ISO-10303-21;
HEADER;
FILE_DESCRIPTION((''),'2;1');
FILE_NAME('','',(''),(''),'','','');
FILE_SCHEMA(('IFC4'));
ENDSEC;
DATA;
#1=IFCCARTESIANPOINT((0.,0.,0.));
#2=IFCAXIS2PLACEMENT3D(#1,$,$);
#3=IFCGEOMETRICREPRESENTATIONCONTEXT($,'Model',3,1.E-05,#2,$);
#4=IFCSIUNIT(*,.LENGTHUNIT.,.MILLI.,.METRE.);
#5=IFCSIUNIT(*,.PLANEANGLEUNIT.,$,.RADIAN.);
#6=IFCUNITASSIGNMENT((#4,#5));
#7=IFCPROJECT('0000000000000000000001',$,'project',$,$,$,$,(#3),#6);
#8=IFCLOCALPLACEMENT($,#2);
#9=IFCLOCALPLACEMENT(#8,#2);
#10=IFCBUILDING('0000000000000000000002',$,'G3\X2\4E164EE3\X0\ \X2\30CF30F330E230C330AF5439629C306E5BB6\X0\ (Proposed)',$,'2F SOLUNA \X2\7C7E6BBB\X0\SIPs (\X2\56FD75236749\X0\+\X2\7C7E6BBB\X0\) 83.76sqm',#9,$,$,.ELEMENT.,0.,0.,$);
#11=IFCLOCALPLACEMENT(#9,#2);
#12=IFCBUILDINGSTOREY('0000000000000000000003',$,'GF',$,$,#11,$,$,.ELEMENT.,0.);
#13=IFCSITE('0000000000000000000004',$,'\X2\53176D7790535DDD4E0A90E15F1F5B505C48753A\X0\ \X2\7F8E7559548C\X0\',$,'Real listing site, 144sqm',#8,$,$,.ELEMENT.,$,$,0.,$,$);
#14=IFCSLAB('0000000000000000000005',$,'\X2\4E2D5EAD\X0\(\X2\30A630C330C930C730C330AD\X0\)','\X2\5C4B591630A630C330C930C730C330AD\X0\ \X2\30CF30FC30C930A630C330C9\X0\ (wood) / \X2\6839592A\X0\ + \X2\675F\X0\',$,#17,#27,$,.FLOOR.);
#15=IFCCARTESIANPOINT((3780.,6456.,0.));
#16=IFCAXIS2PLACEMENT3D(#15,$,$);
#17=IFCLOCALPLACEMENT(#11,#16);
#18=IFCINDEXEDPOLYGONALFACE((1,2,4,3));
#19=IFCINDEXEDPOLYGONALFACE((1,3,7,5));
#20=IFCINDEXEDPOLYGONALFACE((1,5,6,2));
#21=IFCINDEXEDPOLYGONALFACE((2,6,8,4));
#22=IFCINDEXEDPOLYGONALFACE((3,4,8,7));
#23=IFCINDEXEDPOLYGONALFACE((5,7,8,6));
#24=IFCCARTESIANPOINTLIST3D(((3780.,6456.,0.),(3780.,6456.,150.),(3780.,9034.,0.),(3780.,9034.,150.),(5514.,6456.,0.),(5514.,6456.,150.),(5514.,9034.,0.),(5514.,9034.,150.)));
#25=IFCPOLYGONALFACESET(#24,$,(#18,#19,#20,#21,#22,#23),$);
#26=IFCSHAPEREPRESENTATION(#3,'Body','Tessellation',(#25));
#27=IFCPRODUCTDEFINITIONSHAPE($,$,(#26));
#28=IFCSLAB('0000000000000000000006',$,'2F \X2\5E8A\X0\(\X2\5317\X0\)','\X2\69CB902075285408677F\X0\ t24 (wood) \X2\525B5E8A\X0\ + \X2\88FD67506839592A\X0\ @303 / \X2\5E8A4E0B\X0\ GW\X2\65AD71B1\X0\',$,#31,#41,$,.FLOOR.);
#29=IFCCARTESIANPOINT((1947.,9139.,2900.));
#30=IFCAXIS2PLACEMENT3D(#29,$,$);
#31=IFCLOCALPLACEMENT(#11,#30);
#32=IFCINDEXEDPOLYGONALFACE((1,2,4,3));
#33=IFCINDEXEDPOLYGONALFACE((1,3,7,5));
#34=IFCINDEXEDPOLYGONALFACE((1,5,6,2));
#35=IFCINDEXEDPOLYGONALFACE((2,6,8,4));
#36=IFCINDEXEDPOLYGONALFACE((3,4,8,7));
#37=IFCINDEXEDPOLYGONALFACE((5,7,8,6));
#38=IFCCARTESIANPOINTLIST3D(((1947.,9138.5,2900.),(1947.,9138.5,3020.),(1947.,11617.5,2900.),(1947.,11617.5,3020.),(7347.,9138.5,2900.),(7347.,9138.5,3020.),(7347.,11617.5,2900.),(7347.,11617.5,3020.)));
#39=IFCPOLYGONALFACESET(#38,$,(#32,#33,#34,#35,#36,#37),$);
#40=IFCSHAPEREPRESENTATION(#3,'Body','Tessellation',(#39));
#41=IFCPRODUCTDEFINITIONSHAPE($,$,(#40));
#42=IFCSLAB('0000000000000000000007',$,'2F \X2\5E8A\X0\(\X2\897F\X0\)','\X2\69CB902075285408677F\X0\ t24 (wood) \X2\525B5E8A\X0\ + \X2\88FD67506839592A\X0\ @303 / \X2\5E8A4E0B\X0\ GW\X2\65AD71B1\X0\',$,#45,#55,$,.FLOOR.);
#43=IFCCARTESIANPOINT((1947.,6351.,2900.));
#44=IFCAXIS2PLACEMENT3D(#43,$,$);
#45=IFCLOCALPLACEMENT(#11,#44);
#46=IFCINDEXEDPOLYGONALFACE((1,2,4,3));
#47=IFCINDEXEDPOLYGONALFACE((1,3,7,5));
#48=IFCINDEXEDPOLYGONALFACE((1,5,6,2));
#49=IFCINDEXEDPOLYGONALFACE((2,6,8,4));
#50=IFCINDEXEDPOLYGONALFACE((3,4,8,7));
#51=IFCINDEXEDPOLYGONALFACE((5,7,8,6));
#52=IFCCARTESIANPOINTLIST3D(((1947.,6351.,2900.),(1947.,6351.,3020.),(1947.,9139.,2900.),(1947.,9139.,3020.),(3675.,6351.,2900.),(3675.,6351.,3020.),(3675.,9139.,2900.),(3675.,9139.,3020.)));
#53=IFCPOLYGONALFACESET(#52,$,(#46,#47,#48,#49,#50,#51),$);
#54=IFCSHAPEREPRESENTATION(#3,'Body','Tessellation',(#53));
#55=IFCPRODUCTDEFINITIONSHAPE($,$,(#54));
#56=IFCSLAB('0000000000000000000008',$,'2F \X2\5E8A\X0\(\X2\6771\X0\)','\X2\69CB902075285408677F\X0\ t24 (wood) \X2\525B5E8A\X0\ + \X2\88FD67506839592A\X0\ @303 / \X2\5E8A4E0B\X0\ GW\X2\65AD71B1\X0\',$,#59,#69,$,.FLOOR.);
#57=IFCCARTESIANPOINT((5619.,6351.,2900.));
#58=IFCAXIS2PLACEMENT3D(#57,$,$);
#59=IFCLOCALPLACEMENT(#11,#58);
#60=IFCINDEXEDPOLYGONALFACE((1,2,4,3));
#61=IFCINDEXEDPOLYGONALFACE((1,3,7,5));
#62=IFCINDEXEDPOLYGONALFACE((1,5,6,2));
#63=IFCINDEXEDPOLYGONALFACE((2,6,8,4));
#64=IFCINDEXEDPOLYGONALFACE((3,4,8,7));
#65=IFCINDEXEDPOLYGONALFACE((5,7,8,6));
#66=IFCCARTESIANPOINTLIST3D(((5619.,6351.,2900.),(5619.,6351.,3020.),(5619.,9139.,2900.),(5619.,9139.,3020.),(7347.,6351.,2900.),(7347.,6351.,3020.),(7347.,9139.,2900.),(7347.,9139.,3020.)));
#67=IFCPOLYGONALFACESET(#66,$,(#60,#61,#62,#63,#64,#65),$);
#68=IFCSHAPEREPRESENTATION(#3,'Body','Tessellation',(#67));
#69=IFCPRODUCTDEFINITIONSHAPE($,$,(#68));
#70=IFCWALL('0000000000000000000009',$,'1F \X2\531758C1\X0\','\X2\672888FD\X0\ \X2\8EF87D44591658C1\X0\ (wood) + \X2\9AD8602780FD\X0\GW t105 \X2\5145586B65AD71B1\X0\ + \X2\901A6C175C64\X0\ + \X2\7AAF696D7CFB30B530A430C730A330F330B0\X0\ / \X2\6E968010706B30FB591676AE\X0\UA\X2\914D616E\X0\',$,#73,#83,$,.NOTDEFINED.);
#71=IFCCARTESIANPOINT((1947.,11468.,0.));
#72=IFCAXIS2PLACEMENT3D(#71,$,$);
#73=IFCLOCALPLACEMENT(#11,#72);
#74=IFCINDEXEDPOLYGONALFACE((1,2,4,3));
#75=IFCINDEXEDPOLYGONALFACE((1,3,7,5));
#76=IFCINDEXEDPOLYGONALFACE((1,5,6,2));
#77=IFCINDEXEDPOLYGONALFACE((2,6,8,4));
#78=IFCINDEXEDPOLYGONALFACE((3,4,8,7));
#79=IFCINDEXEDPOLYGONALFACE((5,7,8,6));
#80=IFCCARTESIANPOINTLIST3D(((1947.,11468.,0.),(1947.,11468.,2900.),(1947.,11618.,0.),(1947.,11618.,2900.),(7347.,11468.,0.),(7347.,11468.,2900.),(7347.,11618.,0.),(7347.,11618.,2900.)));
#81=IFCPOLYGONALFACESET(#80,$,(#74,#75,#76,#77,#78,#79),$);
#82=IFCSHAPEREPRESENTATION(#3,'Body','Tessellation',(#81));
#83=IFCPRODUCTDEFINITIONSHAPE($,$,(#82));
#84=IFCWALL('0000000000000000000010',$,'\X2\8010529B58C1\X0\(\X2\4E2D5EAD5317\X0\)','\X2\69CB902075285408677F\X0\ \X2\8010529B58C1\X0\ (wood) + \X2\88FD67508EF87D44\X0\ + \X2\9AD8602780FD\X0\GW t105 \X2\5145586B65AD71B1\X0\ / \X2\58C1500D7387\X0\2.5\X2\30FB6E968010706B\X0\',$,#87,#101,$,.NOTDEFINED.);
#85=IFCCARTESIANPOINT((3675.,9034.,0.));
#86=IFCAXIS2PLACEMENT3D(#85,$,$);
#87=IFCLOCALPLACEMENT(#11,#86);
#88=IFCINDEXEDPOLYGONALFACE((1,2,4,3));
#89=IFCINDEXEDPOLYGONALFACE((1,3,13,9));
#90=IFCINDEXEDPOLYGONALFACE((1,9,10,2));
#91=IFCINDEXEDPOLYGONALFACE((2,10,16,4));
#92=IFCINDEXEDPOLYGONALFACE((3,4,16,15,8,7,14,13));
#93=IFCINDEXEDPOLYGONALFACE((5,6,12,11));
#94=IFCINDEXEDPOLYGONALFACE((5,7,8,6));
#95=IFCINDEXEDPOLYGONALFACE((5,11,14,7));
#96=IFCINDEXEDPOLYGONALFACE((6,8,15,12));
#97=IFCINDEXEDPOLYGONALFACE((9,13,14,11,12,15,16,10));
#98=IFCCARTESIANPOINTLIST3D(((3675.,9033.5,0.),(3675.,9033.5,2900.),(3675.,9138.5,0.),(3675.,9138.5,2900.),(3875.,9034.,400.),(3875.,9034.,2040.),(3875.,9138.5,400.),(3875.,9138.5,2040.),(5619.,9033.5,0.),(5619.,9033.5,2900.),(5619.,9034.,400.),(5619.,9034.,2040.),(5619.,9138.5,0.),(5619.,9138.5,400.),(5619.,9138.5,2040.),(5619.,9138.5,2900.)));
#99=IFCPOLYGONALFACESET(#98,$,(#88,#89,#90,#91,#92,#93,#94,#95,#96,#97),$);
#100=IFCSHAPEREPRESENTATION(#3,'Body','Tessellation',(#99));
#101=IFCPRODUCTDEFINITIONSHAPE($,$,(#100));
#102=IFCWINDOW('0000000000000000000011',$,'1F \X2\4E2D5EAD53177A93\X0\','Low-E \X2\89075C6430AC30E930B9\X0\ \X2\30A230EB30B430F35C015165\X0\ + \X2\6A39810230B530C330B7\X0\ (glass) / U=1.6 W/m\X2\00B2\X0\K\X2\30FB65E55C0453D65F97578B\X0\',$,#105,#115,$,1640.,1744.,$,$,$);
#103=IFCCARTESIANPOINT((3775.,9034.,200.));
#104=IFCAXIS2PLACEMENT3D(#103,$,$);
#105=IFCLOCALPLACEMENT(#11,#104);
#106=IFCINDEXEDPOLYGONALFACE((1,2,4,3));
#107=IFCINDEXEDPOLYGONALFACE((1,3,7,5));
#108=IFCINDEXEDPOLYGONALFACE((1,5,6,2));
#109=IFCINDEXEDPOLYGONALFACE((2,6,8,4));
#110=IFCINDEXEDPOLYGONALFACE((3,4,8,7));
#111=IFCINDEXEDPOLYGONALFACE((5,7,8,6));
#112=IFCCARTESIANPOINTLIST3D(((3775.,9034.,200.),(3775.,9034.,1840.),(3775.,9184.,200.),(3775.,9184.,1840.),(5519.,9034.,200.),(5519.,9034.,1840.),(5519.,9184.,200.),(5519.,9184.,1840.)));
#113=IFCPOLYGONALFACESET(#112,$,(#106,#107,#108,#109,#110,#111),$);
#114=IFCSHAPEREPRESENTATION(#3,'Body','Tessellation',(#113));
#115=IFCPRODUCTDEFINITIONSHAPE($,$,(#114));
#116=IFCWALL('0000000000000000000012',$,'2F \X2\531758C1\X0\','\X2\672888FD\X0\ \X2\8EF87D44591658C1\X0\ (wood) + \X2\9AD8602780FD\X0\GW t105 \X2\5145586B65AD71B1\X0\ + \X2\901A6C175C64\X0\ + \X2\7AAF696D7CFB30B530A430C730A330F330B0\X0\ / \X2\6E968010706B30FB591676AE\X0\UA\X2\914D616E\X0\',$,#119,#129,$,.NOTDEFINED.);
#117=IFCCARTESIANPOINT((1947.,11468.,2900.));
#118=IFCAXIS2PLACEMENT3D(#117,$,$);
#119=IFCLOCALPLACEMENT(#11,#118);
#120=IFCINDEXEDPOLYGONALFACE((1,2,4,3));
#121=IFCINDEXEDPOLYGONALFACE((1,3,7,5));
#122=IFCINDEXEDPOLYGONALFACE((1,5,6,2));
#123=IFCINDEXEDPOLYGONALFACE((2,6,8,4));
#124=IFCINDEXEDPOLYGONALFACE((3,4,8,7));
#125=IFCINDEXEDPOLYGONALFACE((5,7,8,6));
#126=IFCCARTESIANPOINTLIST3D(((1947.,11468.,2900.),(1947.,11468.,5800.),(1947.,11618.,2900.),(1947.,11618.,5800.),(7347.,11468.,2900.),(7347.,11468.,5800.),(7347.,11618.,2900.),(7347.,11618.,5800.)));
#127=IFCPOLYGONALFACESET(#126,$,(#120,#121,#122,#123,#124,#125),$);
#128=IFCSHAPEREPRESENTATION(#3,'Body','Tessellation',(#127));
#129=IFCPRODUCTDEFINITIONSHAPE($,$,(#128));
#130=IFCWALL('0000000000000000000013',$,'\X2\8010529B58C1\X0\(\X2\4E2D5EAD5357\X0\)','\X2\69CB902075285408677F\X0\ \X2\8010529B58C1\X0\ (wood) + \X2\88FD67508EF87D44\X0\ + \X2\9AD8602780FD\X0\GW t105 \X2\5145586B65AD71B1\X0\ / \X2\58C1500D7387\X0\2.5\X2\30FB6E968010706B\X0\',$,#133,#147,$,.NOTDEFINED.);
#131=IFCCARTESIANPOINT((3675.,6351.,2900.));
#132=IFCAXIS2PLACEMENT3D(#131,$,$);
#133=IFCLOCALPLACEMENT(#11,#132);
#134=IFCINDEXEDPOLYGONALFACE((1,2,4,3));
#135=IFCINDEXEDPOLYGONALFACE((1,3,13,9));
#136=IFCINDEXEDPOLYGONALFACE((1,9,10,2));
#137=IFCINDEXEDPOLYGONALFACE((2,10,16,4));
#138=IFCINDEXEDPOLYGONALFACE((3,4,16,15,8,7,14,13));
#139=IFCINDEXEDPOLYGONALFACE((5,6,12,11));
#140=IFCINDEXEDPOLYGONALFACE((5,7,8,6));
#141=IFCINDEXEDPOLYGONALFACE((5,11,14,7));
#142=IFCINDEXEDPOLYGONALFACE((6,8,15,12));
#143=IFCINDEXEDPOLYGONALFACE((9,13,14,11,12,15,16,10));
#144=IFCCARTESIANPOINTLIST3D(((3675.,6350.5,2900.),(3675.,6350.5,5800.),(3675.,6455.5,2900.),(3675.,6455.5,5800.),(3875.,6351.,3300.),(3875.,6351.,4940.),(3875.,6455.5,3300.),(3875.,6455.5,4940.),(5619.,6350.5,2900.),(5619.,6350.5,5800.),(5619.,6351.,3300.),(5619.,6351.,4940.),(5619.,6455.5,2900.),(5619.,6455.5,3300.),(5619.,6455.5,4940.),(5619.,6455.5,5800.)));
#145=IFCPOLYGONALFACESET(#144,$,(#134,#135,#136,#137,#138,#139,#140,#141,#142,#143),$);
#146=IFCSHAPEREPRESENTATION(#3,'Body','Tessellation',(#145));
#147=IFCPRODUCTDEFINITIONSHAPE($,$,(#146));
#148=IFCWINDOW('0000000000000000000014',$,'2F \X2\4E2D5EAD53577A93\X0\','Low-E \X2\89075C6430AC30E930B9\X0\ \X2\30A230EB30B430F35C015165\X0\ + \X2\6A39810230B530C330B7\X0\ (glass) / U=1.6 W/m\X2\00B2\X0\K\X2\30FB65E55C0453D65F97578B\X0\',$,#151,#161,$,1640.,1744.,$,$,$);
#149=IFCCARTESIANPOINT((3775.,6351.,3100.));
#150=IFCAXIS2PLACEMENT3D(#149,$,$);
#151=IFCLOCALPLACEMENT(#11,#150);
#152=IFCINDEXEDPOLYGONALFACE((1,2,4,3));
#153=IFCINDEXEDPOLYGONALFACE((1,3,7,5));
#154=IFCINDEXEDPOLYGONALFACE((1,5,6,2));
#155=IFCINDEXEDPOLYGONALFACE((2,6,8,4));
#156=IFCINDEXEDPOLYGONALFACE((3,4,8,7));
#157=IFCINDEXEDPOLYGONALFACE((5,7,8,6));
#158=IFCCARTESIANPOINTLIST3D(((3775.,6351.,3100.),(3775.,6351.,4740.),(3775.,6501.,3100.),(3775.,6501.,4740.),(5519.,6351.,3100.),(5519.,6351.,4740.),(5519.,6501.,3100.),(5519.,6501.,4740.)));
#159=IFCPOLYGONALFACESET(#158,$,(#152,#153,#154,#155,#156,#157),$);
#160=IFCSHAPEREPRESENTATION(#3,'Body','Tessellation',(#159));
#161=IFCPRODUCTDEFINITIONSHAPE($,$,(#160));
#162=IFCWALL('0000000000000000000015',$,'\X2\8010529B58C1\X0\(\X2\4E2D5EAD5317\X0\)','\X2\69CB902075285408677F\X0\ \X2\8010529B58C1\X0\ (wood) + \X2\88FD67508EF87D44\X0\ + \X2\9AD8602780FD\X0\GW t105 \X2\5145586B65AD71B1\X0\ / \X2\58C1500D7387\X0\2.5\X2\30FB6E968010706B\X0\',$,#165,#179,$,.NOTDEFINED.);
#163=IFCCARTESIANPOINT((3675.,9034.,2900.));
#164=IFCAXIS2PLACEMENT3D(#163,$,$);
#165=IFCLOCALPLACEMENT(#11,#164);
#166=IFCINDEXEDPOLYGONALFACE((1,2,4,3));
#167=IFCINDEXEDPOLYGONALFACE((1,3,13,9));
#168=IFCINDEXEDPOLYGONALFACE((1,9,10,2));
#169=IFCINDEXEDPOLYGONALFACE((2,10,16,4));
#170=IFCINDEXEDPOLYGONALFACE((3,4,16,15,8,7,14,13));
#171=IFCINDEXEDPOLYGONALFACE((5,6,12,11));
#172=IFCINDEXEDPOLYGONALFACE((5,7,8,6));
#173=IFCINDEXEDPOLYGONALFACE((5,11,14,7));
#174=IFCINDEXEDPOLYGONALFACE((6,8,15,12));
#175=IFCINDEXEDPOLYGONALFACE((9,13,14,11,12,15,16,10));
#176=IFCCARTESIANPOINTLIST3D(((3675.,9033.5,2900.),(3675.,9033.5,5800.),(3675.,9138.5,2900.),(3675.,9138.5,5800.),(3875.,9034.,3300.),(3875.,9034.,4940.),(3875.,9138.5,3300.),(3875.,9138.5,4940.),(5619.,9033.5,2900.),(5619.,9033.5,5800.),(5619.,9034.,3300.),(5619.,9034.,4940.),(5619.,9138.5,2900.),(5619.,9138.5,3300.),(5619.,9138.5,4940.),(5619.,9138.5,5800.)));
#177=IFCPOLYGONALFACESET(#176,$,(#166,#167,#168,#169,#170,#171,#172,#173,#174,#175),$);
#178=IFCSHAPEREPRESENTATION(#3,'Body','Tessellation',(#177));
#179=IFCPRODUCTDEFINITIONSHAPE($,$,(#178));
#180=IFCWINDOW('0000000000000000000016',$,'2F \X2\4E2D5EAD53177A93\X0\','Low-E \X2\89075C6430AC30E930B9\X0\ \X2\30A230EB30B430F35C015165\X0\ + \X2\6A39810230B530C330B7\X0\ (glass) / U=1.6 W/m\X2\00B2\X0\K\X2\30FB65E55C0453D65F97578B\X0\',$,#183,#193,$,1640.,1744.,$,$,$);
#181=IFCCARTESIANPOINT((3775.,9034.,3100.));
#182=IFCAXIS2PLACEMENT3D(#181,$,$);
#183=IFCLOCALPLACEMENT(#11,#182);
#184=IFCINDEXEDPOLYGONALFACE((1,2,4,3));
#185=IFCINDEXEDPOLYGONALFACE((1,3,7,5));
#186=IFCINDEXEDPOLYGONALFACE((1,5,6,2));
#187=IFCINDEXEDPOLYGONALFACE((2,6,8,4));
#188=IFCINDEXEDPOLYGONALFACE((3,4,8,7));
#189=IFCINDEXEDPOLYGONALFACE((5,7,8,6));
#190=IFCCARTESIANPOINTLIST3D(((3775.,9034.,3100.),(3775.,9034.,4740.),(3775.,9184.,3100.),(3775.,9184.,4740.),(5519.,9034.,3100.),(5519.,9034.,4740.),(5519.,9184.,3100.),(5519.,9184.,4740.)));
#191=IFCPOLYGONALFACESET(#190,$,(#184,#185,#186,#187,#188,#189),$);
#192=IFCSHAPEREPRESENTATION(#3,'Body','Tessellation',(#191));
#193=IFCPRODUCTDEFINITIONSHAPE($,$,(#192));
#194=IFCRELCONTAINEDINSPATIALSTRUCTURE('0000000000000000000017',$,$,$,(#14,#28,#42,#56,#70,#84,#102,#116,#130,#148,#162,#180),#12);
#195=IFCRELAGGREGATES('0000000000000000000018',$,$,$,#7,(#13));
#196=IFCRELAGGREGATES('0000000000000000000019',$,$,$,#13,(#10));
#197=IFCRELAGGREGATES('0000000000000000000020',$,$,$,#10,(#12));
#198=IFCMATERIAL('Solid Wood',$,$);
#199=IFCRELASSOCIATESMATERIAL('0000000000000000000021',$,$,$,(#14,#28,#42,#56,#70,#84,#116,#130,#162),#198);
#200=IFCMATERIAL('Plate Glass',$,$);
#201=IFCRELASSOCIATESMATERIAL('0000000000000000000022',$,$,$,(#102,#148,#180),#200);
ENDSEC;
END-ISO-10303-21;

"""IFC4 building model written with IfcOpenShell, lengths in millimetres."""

from ifc_helpers import new_model, si_unit, frame, frame_2d, origin, place, context, project, spatial, rectangle, extrude, material, element, fill, save


model = new_model("IFC4")

# Units and contexts
model_context = context("Model", 3, precision=1e-05, world=origin())
ifc_project = project(units=[si_unit("LENGTHUNIT", "METRE", prefix="MILLI"), si_unit("PLANEANGLEUNIT", "RADIAN")], contexts=[model_context])

# Site, building, storey
site_placement = place(None, origin())
site = spatial("IfcSite", under=ifc_project, at=site_placement, Name="北海道川上郡弟子屈町 美留和", ObjectType="Real listing site, 144sqm", CompositionType="ELEMENT", RefElevation=0.0)
building_placement = place(site_placement, origin())
building = spatial("IfcBuilding", under=site, at=building_placement, Name="G3世代 ハンモック吹抜の家 (Proposed)", ObjectType="2F SOLUNA 籾殻SIPs (国産杉+籾殻) 83.76sqm", CompositionType="ELEMENT", ElevationOfRefHeight=0.0, ElevationOfTerrain=0.0)
storey_placement = place(building_placement, origin())
storey = spatial("IfcBuildingStorey", under=building, at=storey_placement, Name="GF", CompositionType="ELEMENT", Elevation=0.0)

# Slabs
ifc_material_1 = material(Name="Solid Wood")
slab_1_placement = place(storey_placement, frame((3780.0, 6456.0, 0.0)))
element("IfcSlab", 1, at=slab_1_placement, inside=storey, material=ifc_material_1, Name="中庭(ウッドデッキ)", Description="屋外ウッドデッキ ハードウッド (wood) / 根太 + 束", PredefinedType="FLOOR", context=model_context, shape_type="SweptSolid", body=[
    extrude(rectangle(XDim=1734.0, YDim=2578.0, at=frame_2d((867.0, 1289.0))), frame((3780.0, 6456.0, 0.0)), (0.0, 0.0, 1.0), 150.0),
])
slab_2_placement = place(storey_placement, frame((1947.0, 9139.0, 2900.0)))
element("IfcSlab", 2, at=slab_2_placement, inside=storey, material=ifc_material_1, Name="2F 床(北)", Description="構造用合板 t24 (wood) 剛床 + 製材根太 @303 / 床下 GW断熱", PredefinedType="FLOOR", context=model_context, shape_type="SweptSolid", body=[
    extrude(rectangle(XDim=5400.0, YDim=2479.0, at=frame_2d((2700.0, 1239.0))), frame((1947.0, 9139.0, 2900.0)), (0.0, 0.0, 1.0), 120.0),
])
slab_3_placement = place(storey_placement, frame((1947.0, 6351.0, 2900.0)))
element("IfcSlab", 3, at=slab_3_placement, inside=storey, material=ifc_material_1, Name="2F 床(西)", Description="構造用合板 t24 (wood) 剛床 + 製材根太 @303 / 床下 GW断熱", PredefinedType="FLOOR", context=model_context, shape_type="SweptSolid", body=[
    extrude(rectangle(XDim=1728.0, YDim=2788.0, at=frame_2d((864.0, 1394.0))), frame((1947.0, 6351.0, 2900.0)), (0.0, 0.0, 1.0), 120.0),
])
slab_4_placement = place(storey_placement, frame((5619.0, 6351.0, 2900.0)))
element("IfcSlab", 4, at=slab_4_placement, inside=storey, material=ifc_material_1, Name="2F 床(東)", Description="構造用合板 t24 (wood) 剛床 + 製材根太 @303 / 床下 GW断熱", PredefinedType="FLOOR", context=model_context, shape_type="SweptSolid", body=[
    extrude(rectangle(XDim=1728.0, YDim=2788.0, at=frame_2d((864.0, 1394.0))), frame((5619.0, 6351.0, 2900.0)), (0.0, 0.0, 1.0), 120.0),
])

# Wall
wall_1_placement = place(storey_placement, frame((1947.0, 11468.0, 0.0)))
element("IfcWall", 5, at=wall_1_placement, inside=storey, material=ifc_material_1, Name="1F 北壁", Description="木製 軸組外壁 (wood) + 高性能GW t105 充填断熱 + 通気層 + 窯業系サイディング / 準耐火・外皮UA配慮", PredefinedType="NOTDEFINED", context=model_context, shape_type="SweptSolid", body=[
    extrude(rectangle(XDim=5400.0, YDim=150.0, at=frame_2d((2700.0, 75.0))), frame((1947.0, 11468.0, 0.0)), (0.0, 0.0, 1.0), 2900.0),
])

# Wall, opening, window
wall_2_placement = place(storey_placement, frame((3675.0, 9034.0, 0.0)))
wall_2 = element("IfcWall", 6, at=wall_2_placement, inside=storey, material=ifc_material_1, Name="耐力壁(中庭北)", Description="構造用合板 耐力壁 (wood) + 製材軸組 + 高性能GW t105 充填断熱 / 壁倍率2.5・準耐火", PredefinedType="NOTDEFINED", context=model_context, shape_type="SweptSolid", body=[
    extrude(rectangle(XDim=1944.0, YDim=105.0, at=frame_2d((972.0, 52.0))), frame((3675.0, 9034.0, 0.0)), (0.0, 0.0, 1.0), 2900.0),
])
opening_1_placement = place(storey_placement, frame((3775.0, 9034.0, 200.0)))
opening_1 = element("IfcOpeningElement", 7, at=opening_1_placement, cuts=wall_2, PredefinedType="NOTDEFINED", context=model_context, shape_type="SweptSolid", body=[
    extrude(rectangle(XDim=1744.0, YDim=150.0, at=frame_2d((872.0, 75.0))), frame((3775.0, 9034.0, 200.0)), (0.0, 0.0, 1.0), 1640.0),
])
ifc_material_2 = material(Name="Plate Glass")
window_1_placement = place(storey_placement, frame((3775.0, 9034.0, 200.0)))
window_1 = element("IfcWindow", 8, at=window_1_placement, inside=storey, material=ifc_material_2, Name="1F 中庭北窓", Description="Low-E 複層ガラス アルゴン封入 + 樹脂サッシ (glass) / U=1.6 W/m²K・日射取得型", OverallHeight=1640.0, OverallWidth=1744.0, context=model_context, shape_type="SweptSolid", body=[
    extrude(rectangle(XDim=1744.0, YDim=150.0, at=frame_2d((872.0, 75.0))), frame((3775.0, 9034.0, 200.0)), (0.0, 0.0, 1.0), 1640.0),
])
fill(opening_1, window_1)

# Wall
wall_3_placement = place(storey_placement, frame((1947.0, 11468.0, 2900.0)))
element("IfcWall", 9, at=wall_3_placement, inside=storey, material=ifc_material_1, Name="2F 北壁", Description="木製 軸組外壁 (wood) + 高性能GW t105 充填断熱 + 通気層 + 窯業系サイディング / 準耐火・外皮UA配慮", PredefinedType="NOTDEFINED", context=model_context, shape_type="SweptSolid", body=[
    extrude(rectangle(XDim=5400.0, YDim=150.0, at=frame_2d((2700.0, 75.0))), frame((1947.0, 11468.0, 2900.0)), (0.0, 0.0, 1.0), 2900.0),
])

# Walls, openings, windows
wall_4_placement = place(storey_placement, frame((3675.0, 6351.0, 2900.0)))
wall_4 = element("IfcWall", 10, at=wall_4_placement, inside=storey, material=ifc_material_1, Name="耐力壁(中庭南)", Description="構造用合板 耐力壁 (wood) + 製材軸組 + 高性能GW t105 充填断熱 / 壁倍率2.5・準耐火", PredefinedType="NOTDEFINED", context=model_context, shape_type="SweptSolid", body=[
    extrude(rectangle(XDim=1944.0, YDim=105.0, at=frame_2d((972.0, 52.0))), frame((3675.0, 6351.0, 2900.0)), (0.0, 0.0, 1.0), 2900.0),
])
opening_2_placement = place(storey_placement, frame((3775.0, 6351.0, 3100.0)))
opening_2 = element("IfcOpeningElement", 11, at=opening_2_placement, cuts=wall_4, PredefinedType="NOTDEFINED", context=model_context, shape_type="SweptSolid", body=[
    extrude(rectangle(XDim=1744.0, YDim=150.0, at=frame_2d((872.0, 75.0))), frame((3775.0, 6351.0, 3100.0)), (0.0, 0.0, 1.0), 1640.0),
])
window_2_placement = place(storey_placement, frame((3775.0, 6351.0, 3100.0)))
window_2 = element("IfcWindow", 12, at=window_2_placement, inside=storey, material=ifc_material_2, Name="2F 中庭南窓", Description="Low-E 複層ガラス アルゴン封入 + 樹脂サッシ (glass) / U=1.6 W/m²K・日射取得型", OverallHeight=1640.0, OverallWidth=1744.0, context=model_context, shape_type="SweptSolid", body=[
    extrude(rectangle(XDim=1744.0, YDim=150.0, at=frame_2d((872.0, 75.0))), frame((3775.0, 6351.0, 3100.0)), (0.0, 0.0, 1.0), 1640.0),
])
fill(opening_2, window_2)
wall_5_placement = place(storey_placement, frame((3675.0, 9034.0, 2900.0)))
wall_5 = element("IfcWall", 13, at=wall_5_placement, inside=storey, material=ifc_material_1, Name="耐力壁(中庭北)", Description="構造用合板 耐力壁 (wood) + 製材軸組 + 高性能GW t105 充填断熱 / 壁倍率2.5・準耐火", PredefinedType="NOTDEFINED", context=model_context, shape_type="SweptSolid", body=[
    extrude(rectangle(XDim=1944.0, YDim=105.0, at=frame_2d((972.0, 52.0))), frame((3675.0, 9034.0, 2900.0)), (0.0, 0.0, 1.0), 2900.0),
])
opening_3_placement = place(storey_placement, frame((3775.0, 9034.0, 3100.0)))
opening_3 = element("IfcOpeningElement", 14, at=opening_3_placement, cuts=wall_5, PredefinedType="NOTDEFINED", context=model_context, shape_type="SweptSolid", body=[
    extrude(rectangle(XDim=1744.0, YDim=150.0, at=frame_2d((872.0, 75.0))), frame((3775.0, 9034.0, 3100.0)), (0.0, 0.0, 1.0), 1640.0),
])
window_3_placement = place(storey_placement, frame((3775.0, 9034.0, 3100.0)))
window_3 = element("IfcWindow", 15, at=window_3_placement, inside=storey, material=ifc_material_2, Name="2F 中庭北窓", Description="Low-E 複層ガラス アルゴン封入 + 樹脂サッシ (glass) / U=1.6 W/m²K・日射取得型", OverallHeight=1640.0, OverallWidth=1744.0, context=model_context, shape_type="SweptSolid", body=[
    extrude(rectangle(XDim=1744.0, YDim=150.0, at=frame_2d((872.0, 75.0))), frame((3775.0, 9034.0, 3100.0)), (0.0, 0.0, 1.0), 1640.0),
])
fill(opening_3, window_3)

save(model, "model.ifc")
